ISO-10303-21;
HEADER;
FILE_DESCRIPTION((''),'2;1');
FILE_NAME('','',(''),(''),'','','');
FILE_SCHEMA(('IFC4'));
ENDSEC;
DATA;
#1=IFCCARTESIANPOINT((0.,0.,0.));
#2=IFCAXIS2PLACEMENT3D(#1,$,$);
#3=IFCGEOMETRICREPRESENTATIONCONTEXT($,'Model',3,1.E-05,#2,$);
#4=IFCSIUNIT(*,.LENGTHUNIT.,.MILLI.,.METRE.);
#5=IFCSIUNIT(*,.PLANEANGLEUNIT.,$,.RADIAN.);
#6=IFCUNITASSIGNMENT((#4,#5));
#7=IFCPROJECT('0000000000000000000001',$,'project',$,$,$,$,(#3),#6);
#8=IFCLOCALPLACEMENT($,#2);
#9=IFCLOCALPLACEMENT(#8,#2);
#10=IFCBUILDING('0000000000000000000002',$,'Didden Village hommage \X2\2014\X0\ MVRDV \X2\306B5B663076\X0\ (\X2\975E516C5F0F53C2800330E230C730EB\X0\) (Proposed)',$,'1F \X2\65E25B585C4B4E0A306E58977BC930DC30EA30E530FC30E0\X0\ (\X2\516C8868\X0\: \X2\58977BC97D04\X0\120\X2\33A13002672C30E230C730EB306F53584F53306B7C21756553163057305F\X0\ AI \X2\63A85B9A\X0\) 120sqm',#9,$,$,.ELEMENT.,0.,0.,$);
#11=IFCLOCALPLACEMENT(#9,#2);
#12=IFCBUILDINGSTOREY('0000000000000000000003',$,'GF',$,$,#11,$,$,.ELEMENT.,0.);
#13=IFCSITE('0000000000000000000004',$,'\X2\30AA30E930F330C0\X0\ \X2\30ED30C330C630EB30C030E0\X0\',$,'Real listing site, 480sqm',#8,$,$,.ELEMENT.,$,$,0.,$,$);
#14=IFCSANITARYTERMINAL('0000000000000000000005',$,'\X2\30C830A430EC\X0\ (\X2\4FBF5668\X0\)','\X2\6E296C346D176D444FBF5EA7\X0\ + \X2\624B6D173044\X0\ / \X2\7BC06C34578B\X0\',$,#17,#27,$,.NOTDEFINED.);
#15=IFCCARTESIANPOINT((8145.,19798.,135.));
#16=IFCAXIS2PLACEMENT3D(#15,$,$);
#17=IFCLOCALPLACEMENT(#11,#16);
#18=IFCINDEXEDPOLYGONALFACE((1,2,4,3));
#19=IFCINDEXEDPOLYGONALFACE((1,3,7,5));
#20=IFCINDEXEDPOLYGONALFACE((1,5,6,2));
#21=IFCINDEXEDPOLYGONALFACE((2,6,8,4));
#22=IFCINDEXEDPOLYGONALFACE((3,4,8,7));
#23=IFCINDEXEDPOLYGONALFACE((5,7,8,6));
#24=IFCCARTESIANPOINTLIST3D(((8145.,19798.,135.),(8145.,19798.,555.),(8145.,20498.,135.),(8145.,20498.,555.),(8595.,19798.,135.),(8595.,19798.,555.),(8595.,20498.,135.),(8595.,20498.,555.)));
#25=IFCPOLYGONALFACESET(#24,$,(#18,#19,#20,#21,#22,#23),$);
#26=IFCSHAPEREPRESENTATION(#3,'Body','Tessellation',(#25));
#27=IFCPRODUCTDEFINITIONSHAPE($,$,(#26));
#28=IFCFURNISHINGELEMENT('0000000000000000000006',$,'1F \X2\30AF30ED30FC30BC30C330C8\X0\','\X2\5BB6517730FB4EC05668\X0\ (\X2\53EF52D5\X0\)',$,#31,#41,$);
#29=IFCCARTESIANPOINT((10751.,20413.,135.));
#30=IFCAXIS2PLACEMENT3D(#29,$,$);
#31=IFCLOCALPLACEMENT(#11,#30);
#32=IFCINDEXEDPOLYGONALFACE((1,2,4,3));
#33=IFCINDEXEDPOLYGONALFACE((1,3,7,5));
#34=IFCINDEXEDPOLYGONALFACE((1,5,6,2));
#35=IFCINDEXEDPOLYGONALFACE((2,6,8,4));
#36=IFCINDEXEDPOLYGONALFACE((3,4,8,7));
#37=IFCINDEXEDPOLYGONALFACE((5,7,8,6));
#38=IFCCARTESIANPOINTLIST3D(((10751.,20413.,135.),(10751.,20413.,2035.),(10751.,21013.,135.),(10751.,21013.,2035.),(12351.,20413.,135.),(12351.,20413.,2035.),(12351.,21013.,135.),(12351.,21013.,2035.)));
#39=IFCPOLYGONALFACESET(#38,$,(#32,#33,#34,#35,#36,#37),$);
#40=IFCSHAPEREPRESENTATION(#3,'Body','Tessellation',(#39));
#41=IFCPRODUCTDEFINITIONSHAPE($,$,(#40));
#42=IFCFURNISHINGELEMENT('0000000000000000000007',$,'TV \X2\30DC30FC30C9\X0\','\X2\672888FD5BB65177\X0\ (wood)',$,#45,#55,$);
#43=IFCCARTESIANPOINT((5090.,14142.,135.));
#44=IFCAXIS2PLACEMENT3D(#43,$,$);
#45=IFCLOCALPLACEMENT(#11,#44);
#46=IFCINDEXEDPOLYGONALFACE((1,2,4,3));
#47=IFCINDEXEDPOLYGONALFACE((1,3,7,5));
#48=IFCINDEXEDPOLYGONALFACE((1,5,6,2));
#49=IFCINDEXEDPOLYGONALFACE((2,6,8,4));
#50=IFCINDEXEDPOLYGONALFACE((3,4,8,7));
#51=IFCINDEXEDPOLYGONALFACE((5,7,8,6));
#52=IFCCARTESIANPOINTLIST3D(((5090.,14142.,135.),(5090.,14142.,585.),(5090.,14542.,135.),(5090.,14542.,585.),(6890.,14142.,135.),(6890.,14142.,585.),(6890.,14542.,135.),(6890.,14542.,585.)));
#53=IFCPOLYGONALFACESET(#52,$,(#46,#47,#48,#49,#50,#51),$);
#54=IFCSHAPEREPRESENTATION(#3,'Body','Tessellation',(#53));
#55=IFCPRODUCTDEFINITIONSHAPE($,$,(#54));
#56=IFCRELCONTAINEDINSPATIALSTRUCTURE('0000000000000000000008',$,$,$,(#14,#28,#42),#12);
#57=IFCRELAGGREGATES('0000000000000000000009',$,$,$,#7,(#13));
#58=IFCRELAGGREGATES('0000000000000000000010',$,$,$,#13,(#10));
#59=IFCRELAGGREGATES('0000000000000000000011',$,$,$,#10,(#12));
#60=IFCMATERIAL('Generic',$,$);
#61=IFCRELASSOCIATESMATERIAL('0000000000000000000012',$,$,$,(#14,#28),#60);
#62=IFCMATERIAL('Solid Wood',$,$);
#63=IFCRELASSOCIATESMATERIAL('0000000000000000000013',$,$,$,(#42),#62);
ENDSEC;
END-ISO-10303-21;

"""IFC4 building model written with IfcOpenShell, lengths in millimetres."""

from ifc_helpers import new_model, si_unit, frame, frame_2d, origin, place, context, project, spatial, rectangle, extrude, material, element, save


model = new_model("IFC4")

# Units and contexts
model_context = context("Model", 3, precision=1e-05, world=origin())
ifc_project = project(units=[si_unit("LENGTHUNIT", "METRE", prefix="MILLI"), si_unit("PLANEANGLEUNIT", "RADIAN")], contexts=[model_context])

# Site, building, storey
site_placement = place(None, origin())
site = spatial("IfcSite", under=ifc_project, at=site_placement, Name="オランダ ロッテルダム", ObjectType="Real listing site, 480sqm", CompositionType="ELEMENT", RefElevation=0.0)
building_placement = place(site_placement, origin())
building = spatial("IfcBuilding", under=site, at=building_placement, Name="Didden Village hommage — MVRDV に学ぶ (非公式参考モデル) (Proposed)", ObjectType="1F 既存屋上の増築ボリューム (公表: 増築約120㎡。本モデルは単体に簡略化した AI 推定) 120sqm", CompositionType="ELEMENT", ElevationOfRefHeight=0.0, ElevationOfTerrain=0.0)
storey_placement = place(building_placement, origin())
storey = spatial("IfcBuildingStorey", under=building, at=storey_placement, Name="GF", CompositionType="ELEMENT", Elevation=0.0)

# Shared definitions
ifc_material_1 = material(Name="Solid Wood")

# Sanitary terminal
ifc_material_2 = material(Name="Generic")
sanitary_terminal_1_placement = place(storey_placement, frame((8145.0, 19798.0, 135.0)))
element("IfcSanitaryTerminal", 1, at=sanitary_terminal_1_placement, inside=storey, material=ifc_material_2, Name="トイレ (便器)", Description="温水洗浄便座 + 手洗い / 節水型", PredefinedType="NOTDEFINED", context=model_context, shape_type="SweptSolid", body=[
    extrude(rectangle(XDim=450.0, YDim=700.0, at=frame_2d((225.0, 350.0))), frame((8145.0, 19798.0, 135.0)), (0.0, 0.0, 1.0), 420.0),
])

# Furnishing elements
furnishing_1_placement = place(storey_placement, frame((10751.0, 20413.0, 135.0)))
element("IfcFurnishingElement", 2, at=furnishing_1_placement, inside=storey, material=ifc_material_2, Name="1F クローゼット", Description="家具・什器 (可動)", context=model_context, shape_type="SweptSolid", body=[
    extrude(rectangle(XDim=1600.0, YDim=600.0, at=frame_2d((800.0, 300.0))), frame((10751.0, 20413.0, 135.0)), (0.0, 0.0, 1.0), 1900.0),
])
furnishing_2_placement = place(storey_placement, frame((5090.0, 14142.0, 135.0)))
element("IfcFurnishingElement", 3, at=furnishing_2_placement, inside=storey, material=ifc_material_1, Name="TV ボード", Description="木製家具 (wood)", context=model_context, shape_type="SweptSolid", body=[
    extrude(rectangle(XDim=1800.0, YDim=400.0, at=frame_2d((900.0, 200.0))), frame((5090.0, 14142.0, 135.0)), (0.0, 0.0, 1.0), 450.0),
])

save(model, "model.ifc")
